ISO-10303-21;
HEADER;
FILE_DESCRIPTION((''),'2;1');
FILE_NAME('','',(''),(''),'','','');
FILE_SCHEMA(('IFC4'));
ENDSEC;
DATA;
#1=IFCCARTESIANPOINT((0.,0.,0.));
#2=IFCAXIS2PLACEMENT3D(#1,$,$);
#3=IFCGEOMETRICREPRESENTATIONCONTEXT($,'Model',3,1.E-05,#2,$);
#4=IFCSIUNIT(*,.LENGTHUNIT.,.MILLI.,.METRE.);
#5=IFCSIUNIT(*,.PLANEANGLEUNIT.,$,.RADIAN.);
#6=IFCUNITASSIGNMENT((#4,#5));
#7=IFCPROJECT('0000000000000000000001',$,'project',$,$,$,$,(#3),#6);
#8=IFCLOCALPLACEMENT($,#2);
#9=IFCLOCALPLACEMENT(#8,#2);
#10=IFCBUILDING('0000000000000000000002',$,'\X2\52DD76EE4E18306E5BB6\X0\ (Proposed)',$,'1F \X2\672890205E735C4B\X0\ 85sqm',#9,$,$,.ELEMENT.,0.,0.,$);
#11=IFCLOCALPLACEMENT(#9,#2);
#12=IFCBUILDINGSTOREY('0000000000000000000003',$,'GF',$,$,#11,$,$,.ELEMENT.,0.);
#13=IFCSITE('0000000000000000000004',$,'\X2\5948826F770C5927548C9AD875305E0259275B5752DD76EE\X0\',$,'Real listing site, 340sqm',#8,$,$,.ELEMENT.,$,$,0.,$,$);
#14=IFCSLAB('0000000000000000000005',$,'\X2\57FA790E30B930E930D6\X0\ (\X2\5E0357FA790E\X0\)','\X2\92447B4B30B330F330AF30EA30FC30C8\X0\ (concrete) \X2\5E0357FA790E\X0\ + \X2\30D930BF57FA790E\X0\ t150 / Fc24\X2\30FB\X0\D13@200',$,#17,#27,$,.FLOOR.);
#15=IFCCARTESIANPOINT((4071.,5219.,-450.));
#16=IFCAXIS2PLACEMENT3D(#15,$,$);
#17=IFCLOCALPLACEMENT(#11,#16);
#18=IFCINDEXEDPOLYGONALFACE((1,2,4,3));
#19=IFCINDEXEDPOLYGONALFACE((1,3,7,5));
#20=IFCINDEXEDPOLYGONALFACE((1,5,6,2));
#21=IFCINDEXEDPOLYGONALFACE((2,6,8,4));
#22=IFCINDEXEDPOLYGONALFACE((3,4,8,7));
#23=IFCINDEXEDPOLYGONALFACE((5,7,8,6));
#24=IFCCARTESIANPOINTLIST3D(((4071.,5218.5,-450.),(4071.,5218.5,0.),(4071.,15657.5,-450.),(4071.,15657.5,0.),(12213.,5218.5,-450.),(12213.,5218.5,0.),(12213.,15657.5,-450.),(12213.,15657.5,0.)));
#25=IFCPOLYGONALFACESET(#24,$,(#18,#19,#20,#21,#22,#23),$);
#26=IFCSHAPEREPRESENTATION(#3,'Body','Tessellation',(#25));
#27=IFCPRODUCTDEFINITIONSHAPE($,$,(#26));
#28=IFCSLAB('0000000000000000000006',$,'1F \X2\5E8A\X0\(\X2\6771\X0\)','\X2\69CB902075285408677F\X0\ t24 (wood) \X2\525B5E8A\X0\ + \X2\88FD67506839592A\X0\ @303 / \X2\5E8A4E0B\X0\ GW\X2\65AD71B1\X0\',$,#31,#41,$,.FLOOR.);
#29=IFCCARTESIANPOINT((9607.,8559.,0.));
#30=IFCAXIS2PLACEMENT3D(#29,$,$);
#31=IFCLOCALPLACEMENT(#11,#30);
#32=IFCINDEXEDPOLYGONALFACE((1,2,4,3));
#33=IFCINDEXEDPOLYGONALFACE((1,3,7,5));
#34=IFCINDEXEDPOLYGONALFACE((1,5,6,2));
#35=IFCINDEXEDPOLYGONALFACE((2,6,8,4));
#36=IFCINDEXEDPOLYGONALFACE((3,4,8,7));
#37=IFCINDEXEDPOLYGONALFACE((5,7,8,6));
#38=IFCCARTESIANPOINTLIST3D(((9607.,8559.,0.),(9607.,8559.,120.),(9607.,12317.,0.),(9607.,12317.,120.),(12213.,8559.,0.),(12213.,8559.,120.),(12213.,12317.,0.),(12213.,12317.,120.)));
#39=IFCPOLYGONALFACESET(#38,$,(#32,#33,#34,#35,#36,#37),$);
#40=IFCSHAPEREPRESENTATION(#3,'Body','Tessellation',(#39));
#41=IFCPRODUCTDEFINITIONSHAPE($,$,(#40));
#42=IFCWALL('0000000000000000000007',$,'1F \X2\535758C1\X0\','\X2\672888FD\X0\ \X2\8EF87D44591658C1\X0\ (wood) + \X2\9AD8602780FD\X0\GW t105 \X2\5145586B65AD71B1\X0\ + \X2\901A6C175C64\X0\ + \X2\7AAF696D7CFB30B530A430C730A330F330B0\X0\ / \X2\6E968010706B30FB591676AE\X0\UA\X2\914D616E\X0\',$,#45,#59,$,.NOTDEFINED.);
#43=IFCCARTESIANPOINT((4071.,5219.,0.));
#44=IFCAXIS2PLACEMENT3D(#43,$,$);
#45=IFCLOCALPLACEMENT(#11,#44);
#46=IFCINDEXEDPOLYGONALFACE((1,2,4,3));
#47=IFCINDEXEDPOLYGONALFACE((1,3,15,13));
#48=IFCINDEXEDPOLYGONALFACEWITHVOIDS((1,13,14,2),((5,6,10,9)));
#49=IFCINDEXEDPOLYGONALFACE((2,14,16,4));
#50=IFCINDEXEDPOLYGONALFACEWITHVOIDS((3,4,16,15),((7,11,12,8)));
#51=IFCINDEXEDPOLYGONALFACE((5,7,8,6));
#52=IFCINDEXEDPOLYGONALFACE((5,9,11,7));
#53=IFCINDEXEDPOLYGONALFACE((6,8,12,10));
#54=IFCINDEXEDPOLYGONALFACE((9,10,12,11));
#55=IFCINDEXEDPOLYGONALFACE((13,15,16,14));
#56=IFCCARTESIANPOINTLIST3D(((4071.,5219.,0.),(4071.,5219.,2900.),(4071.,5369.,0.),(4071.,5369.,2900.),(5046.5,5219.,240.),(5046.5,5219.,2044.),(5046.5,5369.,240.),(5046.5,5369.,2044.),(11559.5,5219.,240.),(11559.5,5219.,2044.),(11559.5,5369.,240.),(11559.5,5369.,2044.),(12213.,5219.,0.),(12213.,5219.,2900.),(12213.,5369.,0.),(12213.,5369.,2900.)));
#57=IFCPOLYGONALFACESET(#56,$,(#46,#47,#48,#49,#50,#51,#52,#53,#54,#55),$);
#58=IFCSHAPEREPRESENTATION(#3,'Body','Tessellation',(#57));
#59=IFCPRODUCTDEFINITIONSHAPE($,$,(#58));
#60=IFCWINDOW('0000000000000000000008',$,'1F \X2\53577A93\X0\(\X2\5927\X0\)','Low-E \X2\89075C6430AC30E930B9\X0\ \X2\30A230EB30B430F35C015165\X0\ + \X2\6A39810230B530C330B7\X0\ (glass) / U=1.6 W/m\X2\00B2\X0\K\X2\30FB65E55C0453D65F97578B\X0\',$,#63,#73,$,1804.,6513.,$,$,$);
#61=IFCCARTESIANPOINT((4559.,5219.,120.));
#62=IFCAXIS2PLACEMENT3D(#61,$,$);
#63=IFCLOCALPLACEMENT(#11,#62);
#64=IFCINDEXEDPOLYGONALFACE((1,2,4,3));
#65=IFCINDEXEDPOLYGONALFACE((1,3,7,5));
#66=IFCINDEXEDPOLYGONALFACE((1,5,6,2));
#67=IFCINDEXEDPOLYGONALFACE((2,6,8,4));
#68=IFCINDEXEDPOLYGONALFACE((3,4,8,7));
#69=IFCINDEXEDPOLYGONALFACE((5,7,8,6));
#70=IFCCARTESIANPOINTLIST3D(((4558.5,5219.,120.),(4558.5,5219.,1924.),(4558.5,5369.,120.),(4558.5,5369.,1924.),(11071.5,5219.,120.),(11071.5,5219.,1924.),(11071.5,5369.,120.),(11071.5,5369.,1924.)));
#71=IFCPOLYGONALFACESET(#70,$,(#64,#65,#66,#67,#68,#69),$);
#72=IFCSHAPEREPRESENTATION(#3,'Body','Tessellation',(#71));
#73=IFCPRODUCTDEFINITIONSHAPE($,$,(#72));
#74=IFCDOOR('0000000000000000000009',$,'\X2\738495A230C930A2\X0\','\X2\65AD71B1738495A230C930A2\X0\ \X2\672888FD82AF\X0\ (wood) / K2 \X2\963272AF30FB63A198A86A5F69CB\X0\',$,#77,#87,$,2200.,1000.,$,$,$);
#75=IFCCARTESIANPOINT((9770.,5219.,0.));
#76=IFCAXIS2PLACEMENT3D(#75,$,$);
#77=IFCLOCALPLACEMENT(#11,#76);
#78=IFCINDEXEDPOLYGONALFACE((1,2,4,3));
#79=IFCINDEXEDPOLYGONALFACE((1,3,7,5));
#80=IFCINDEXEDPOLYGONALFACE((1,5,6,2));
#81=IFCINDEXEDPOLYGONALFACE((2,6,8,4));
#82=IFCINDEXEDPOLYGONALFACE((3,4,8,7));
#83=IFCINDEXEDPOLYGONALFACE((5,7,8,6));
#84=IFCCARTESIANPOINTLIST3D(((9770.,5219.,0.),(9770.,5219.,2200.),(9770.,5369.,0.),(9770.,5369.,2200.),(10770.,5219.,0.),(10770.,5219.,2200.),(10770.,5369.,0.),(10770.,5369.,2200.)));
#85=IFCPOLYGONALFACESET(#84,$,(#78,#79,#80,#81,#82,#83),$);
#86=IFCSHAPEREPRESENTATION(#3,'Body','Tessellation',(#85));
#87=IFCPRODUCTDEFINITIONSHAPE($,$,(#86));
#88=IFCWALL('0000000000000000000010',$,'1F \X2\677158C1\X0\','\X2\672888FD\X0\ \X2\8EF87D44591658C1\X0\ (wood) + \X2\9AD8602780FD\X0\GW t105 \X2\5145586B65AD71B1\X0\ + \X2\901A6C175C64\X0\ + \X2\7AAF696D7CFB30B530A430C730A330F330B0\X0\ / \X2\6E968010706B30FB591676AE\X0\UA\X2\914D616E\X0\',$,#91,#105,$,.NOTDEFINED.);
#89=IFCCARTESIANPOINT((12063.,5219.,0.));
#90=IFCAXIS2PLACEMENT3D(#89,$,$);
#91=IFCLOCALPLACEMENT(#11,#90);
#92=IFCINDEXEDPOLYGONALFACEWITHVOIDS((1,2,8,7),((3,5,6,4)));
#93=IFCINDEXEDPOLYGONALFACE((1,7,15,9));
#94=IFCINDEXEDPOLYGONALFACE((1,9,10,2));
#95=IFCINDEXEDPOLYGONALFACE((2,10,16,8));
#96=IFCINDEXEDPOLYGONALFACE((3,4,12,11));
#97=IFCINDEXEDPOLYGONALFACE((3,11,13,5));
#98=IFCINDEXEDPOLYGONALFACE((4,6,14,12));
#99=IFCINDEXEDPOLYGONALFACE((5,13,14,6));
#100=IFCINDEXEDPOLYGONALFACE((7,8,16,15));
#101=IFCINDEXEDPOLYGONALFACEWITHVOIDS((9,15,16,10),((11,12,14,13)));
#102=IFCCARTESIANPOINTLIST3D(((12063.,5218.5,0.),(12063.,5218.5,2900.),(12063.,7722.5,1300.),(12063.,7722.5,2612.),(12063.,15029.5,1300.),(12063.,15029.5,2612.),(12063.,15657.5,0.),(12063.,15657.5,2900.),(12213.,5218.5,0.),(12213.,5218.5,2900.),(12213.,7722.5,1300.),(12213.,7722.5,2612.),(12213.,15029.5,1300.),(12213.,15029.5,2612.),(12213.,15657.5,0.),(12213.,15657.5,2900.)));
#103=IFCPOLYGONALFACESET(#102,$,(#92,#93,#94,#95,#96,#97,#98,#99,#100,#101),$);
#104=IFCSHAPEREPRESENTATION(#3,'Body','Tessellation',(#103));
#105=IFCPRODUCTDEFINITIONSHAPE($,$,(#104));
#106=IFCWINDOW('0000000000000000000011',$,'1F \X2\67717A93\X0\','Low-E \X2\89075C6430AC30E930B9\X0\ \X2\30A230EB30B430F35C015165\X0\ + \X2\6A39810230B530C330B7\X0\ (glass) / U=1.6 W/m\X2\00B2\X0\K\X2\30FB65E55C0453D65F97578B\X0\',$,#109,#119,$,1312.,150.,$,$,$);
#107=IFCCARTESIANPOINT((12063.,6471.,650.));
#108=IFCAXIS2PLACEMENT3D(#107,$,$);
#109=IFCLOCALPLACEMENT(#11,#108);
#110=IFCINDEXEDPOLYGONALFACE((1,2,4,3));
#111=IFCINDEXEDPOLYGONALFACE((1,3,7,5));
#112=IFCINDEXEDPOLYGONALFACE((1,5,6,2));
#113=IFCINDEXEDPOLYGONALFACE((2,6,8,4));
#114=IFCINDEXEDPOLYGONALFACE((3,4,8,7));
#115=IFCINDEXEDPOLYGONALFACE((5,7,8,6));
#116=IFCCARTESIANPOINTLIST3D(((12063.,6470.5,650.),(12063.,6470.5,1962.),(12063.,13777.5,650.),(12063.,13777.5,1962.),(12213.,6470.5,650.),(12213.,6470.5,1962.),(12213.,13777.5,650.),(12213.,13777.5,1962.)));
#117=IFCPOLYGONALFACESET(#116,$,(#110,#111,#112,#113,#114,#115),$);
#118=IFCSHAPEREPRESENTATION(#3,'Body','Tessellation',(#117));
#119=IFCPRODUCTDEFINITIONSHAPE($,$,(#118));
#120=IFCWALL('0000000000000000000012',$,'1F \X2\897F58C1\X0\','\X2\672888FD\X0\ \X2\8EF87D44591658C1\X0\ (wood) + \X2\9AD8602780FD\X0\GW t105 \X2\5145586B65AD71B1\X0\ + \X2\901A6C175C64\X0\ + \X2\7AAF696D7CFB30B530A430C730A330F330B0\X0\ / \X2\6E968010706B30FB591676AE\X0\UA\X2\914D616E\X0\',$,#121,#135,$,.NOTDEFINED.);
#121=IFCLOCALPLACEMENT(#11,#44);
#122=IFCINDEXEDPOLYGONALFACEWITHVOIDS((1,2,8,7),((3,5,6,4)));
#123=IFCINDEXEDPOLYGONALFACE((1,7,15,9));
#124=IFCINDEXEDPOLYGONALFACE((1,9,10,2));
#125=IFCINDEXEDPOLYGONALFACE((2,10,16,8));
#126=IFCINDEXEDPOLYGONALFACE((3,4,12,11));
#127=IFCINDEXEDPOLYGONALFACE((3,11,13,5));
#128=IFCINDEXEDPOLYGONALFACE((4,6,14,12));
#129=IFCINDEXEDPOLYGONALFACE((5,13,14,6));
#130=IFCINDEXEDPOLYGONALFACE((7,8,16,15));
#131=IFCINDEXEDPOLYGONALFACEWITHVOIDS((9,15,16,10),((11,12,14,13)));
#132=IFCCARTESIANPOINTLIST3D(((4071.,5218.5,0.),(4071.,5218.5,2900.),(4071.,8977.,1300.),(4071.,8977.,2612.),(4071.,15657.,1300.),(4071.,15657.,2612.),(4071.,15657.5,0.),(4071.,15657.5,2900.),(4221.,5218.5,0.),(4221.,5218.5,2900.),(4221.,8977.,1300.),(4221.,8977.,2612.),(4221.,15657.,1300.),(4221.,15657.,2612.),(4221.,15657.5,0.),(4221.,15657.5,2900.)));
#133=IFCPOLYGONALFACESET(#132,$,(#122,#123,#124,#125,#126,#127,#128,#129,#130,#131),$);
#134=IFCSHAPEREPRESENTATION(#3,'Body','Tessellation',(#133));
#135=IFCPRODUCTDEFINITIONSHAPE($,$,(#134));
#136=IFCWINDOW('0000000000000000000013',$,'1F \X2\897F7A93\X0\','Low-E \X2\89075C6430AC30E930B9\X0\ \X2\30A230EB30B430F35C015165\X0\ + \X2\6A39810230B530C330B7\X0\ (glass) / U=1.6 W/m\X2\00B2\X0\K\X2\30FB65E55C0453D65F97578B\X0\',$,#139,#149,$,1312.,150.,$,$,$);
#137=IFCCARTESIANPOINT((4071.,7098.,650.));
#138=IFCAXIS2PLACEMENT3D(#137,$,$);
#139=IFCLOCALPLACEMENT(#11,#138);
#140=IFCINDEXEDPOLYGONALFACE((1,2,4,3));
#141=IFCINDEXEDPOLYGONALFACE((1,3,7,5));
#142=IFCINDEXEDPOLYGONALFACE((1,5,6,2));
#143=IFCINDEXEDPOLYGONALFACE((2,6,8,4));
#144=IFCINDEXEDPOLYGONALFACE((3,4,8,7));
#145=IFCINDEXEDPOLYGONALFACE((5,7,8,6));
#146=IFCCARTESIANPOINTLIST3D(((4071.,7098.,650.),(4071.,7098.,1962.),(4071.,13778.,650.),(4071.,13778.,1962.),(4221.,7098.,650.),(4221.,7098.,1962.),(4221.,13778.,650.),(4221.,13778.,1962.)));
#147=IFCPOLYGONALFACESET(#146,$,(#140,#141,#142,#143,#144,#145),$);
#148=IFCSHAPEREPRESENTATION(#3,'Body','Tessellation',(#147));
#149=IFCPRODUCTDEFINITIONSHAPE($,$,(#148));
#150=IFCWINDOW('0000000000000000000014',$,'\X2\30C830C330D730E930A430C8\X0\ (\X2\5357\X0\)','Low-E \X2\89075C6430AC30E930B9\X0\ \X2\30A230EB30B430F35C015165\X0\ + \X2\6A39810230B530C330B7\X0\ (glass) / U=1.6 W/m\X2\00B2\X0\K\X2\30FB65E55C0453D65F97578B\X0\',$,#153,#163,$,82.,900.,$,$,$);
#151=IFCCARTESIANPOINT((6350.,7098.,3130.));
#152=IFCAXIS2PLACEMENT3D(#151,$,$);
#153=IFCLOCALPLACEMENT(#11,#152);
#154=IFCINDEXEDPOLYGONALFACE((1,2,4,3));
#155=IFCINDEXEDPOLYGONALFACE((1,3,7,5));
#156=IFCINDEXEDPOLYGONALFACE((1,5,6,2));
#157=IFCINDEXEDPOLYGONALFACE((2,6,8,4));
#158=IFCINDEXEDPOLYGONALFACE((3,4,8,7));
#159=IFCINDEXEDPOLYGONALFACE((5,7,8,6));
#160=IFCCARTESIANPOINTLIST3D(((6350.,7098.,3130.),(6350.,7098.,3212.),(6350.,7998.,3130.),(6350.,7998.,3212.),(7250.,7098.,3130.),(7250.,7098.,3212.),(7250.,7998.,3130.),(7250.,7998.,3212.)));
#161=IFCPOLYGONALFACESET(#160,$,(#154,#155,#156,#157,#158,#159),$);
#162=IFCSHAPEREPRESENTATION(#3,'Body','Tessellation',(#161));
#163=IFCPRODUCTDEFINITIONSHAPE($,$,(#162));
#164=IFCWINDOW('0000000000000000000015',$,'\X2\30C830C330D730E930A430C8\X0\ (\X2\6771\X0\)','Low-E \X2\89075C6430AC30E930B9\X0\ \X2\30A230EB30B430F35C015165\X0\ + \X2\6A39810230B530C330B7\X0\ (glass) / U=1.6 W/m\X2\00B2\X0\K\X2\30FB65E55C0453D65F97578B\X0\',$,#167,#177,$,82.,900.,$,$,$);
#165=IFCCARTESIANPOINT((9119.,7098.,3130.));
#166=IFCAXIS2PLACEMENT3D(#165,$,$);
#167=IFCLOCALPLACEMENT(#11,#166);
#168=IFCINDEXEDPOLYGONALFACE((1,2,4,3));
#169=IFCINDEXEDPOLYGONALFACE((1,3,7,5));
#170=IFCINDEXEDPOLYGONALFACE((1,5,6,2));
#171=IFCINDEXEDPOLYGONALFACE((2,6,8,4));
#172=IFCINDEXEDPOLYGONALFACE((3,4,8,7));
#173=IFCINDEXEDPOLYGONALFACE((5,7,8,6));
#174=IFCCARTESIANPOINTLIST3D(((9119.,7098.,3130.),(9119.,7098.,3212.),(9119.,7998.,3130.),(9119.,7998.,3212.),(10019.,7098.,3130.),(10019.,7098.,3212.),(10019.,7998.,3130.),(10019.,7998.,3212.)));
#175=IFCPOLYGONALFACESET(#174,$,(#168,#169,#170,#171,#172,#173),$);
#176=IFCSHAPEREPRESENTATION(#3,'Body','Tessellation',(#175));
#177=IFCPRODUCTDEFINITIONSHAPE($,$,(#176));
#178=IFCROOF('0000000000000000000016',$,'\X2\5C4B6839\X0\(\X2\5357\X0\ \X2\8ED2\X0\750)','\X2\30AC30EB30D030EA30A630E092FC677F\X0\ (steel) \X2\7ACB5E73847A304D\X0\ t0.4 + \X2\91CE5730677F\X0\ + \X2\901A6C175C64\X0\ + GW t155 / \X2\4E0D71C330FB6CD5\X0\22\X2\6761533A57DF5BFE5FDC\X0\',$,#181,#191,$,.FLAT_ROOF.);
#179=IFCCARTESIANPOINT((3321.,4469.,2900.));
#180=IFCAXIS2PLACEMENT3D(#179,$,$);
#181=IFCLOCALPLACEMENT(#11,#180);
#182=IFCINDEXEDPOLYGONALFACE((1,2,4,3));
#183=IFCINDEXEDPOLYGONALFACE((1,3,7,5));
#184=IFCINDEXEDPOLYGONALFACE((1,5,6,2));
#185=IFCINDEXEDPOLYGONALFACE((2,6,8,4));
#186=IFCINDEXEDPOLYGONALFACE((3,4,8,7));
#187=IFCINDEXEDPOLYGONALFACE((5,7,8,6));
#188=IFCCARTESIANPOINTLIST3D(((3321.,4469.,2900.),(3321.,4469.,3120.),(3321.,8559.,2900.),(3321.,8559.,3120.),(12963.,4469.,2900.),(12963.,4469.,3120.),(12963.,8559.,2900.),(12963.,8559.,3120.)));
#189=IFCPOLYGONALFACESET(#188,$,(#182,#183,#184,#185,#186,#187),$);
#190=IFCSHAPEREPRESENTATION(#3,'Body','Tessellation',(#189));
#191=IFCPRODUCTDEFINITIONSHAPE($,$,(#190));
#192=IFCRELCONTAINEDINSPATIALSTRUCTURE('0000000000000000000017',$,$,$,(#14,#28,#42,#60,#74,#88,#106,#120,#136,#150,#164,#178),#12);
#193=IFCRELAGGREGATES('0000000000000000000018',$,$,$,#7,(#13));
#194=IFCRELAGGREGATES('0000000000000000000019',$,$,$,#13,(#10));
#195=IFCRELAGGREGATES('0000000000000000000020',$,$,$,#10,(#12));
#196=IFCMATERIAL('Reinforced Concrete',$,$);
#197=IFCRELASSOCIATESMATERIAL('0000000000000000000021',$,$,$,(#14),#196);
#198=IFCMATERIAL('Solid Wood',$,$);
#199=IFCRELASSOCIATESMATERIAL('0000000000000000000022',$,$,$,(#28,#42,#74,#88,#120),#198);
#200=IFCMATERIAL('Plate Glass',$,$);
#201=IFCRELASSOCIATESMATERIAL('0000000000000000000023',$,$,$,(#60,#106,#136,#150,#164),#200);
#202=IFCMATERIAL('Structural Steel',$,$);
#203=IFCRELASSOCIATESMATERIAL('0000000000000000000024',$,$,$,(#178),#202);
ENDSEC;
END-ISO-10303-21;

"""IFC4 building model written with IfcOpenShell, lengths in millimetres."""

from ifc_helpers import new_model, si_unit, frame, frame_2d, origin, place, context, project, spatial, rectangle, extrude, material, element, fill, save


model = new_model("IFC4")

# Units and contexts
model_context = context("Model", 3, precision=1e-05, world=origin())
ifc_project = project(units=[si_unit("LENGTHUNIT", "METRE", prefix="MILLI"), si_unit("PLANEANGLEUNIT", "RADIAN")], contexts=[model_context])

# Site, building, storey
site_placement = place(None, origin())
site = spatial("IfcSite", under=ifc_project, at=site_placement, Name="奈良県大和高田市大字勝目", ObjectType="Real listing site, 340sqm", CompositionType="ELEMENT", RefElevation=0.0)
building_placement = place(site_placement, origin())
building = spatial("IfcBuilding", under=site, at=building_placement, Name="勝目丘の家 (Proposed)", ObjectType="1F 木造平屋 85sqm", CompositionType="ELEMENT", ElevationOfRefHeight=0.0, ElevationOfTerrain=0.0)
storey_placement = place(building_placement, origin())
storey = spatial("IfcBuildingStorey", under=building, at=storey_placement, Name="GF", CompositionType="ELEMENT", Elevation=0.0)

# Slabs
ifc_material_1 = material(Name="Reinforced Concrete")
slab_1_placement = place(storey_placement, frame((4071.0, 5219.0, -450.0)))
element("IfcSlab", 1, at=slab_1_placement, inside=storey, material=ifc_material_1, Name="基礎スラブ (布基礎)", Description="鉄筋コンクリート (concrete) 布基礎 + ベタ基礎 t150 / Fc24・D13@200", PredefinedType="FLOOR", context=model_context, shape_type="SweptSolid", body=[
    extrude(rectangle(XDim=8142.0, YDim=10439.0, at=frame_2d((4071.0, 5219.0))), frame((4071.0, 5219.0, -450.0)), (0.0, 0.0, 1.0), 450.0),
])
ifc_material_2 = material(Name="Solid Wood")
slab_2_placement = place(storey_placement, frame((9607.0, 8559.0, 0.0)))
element("IfcSlab", 2, at=slab_2_placement, inside=storey, material=ifc_material_2, Name="1F 床(東)", Description="構造用合板 t24 (wood) 剛床 + 製材根太 @303 / 床下 GW断熱", PredefinedType="FLOOR", context=model_context, shape_type="SweptSolid", body=[
    extrude(rectangle(XDim=2606.0, YDim=3758.0, at=frame_2d((1303.0, 1879.0))), frame((9607.0, 8559.0, 0.0)), (0.0, 0.0, 1.0), 120.0),
])

# Wall, openings, window, door
wall_1_placement = place(storey_placement, frame((4071.0, 5219.0, 0.0)))
wall_1 = element("IfcWall", 3, at=wall_1_placement, inside=storey, material=ifc_material_2, Name="1F 南壁", Description="木製 軸組外壁 (wood) + 高性能GW t105 充填断熱 + 通気層 + 窯業系サイディング / 準耐火・外皮UA配慮", PredefinedType="NOTDEFINED", context=model_context, shape_type="SweptSolid", body=[
    extrude(rectangle(XDim=8142.0, YDim=150.0, at=frame_2d((4071.0, 75.0))), frame((4071.0, 5219.0, 0.0)), (0.0, 0.0, 1.0), 2900.0),
])
opening_1_placement = place(storey_placement, frame((4559.0, 5219.0, 120.0)))
opening_1 = element("IfcOpeningElement", 4, at=opening_1_placement, cuts=wall_1, PredefinedType="NOTDEFINED", context=model_context, shape_type="SweptSolid", body=[
    extrude(rectangle(XDim=6513.0, YDim=150.0, at=frame_2d((3256.0, 75.0))), frame((4559.0, 5219.0, 120.0)), (0.0, 0.0, 1.0), 1804.0),
])
opening_2_placement = place(storey_placement, frame((9770.0, 5219.0, 0.0)))
opening_2 = element("IfcOpeningElement", 5, at=opening_2_placement, cuts=wall_1, PredefinedType="NOTDEFINED", context=model_context, shape_type="SweptSolid", body=[
    extrude(rectangle(XDim=1000.0, YDim=150.0, at=frame_2d((500.0, 75.0))), frame((9770.0, 5219.0, 0.0)), (0.0, 0.0, 1.0), 2200.0),
])
ifc_material_3 = material(Name="Plate Glass")
window_1_placement = place(storey_placement, frame((4559.0, 5219.0, 120.0)))
window_1 = element("IfcWindow", 6, at=window_1_placement, inside=storey, material=ifc_material_3, Name="1F 南窓(大)", Description="Low-E 複層ガラス アルゴン封入 + 樹脂サッシ (glass) / U=1.6 W/m²K・日射取得型", OverallHeight=1804.0, OverallWidth=6513.0, context=model_context, shape_type="SweptSolid", body=[
    extrude(rectangle(XDim=6513.0, YDim=150.0, at=frame_2d((3256.0, 75.0))), frame((4559.0, 5219.0, 120.0)), (0.0, 0.0, 1.0), 1804.0),
])
fill(opening_1, window_1)
door_placement = place(storey_placement, frame((9770.0, 5219.0, 0.0)))
door = element("IfcDoor", 7, at=door_placement, inside=storey, material=ifc_material_2, Name="玄関ドア", Description="断熱玄関ドア 木製芯 (wood) / K2 防犯・採風機構", OverallHeight=2200.0, OverallWidth=1000.0, context=model_context, shape_type="SweptSolid", body=[
    extrude(rectangle(XDim=1000.0, YDim=150.0, at=frame_2d((500.0, 75.0))), frame((9770.0, 5219.0, 0.0)), (0.0, 0.0, 1.0), 2200.0),
])
fill(opening_2, door)

# Walls, openings, windows
wall_2_placement = place(storey_placement, frame((12063.0, 5219.0, 0.0)))
wall_2 = element("IfcWall", 8, at=wall_2_placement, inside=storey, material=ifc_material_2, Name="1F 東壁", Description="木製 軸組外壁 (wood) + 高性能GW t105 充填断熱 + 通気層 + 窯業系サイディング / 準耐火・外皮UA配慮", PredefinedType="NOTDEFINED", context=model_context, shape_type="SweptSolid", body=[
    extrude(rectangle(XDim=150.0, YDim=10439.0, at=frame_2d((75.0, 5219.0))), frame((12063.0, 5219.0, 0.0)), (0.0, 0.0, 1.0), 2900.0),
])
opening_3_placement = place(storey_placement, frame((12063.0, 6471.0, 650.0)))
opening_3 = element("IfcOpeningElement", 9, at=opening_3_placement, cuts=wall_2, PredefinedType="NOTDEFINED", context=model_context, shape_type="SweptSolid", body=[
    extrude(rectangle(XDim=150.0, YDim=7307.0, at=frame_2d((75.0, 3653.0))), frame((12063.0, 6471.0, 650.0)), (0.0, 0.0, 1.0), 1312.0),
])
window_2_placement = place(storey_placement, frame((12063.0, 6471.0, 650.0)))
window_2 = element("IfcWindow", 10, at=window_2_placement, inside=storey, material=ifc_material_3, Name="1F 東窓", Description="Low-E 複層ガラス アルゴン封入 + 樹脂サッシ (glass) / U=1.6 W/m²K・日射取得型", OverallHeight=1312.0, OverallWidth=150.0, context=model_context, shape_type="SweptSolid", body=[
    extrude(rectangle(XDim=150.0, YDim=7307.0, at=frame_2d((75.0, 3653.0))), frame((12063.0, 6471.0, 650.0)), (0.0, 0.0, 1.0), 1312.0),
])
fill(opening_3, window_2)
wall_3_placement = place(storey_placement, frame((4071.0, 5219.0, 0.0)))
wall_3 = element("IfcWall", 11, at=wall_3_placement, inside=storey, material=ifc_material_2, Name="1F 西壁", Description="木製 軸組外壁 (wood) + 高性能GW t105 充填断熱 + 通気層 + 窯業系サイディング / 準耐火・外皮UA配慮", PredefinedType="NOTDEFINED", context=model_context, shape_type="SweptSolid", body=[
    extrude(rectangle(XDim=150.0, YDim=10439.0, at=frame_2d((75.0, 5219.0))), frame((4071.0, 5219.0, 0.0)), (0.0, 0.0, 1.0), 2900.0),
])
opening_4_placement = place(storey_placement, frame((4071.0, 7098.0, 650.0)))
opening_4 = element("IfcOpeningElement", 12, at=opening_4_placement, cuts=wall_3, PredefinedType="NOTDEFINED", context=model_context, shape_type="SweptSolid", body=[
    extrude(rectangle(XDim=150.0, YDim=6680.0, at=frame_2d((75.0, 3340.0))), frame((4071.0, 7098.0, 650.0)), (0.0, 0.0, 1.0), 1312.0),
])
window_3_placement = place(storey_placement, frame((4071.0, 7098.0, 650.0)))
window_3 = element("IfcWindow", 13, at=window_3_placement, inside=storey, material=ifc_material_3, Name="1F 西窓", Description="Low-E 複層ガラス アルゴン封入 + 樹脂サッシ (glass) / U=1.6 W/m²K・日射取得型", OverallHeight=1312.0, OverallWidth=150.0, context=model_context, shape_type="SweptSolid", body=[
    extrude(rectangle(XDim=150.0, YDim=6680.0, at=frame_2d((75.0, 3340.0))), frame((4071.0, 7098.0, 650.0)), (0.0, 0.0, 1.0), 1312.0),
])
fill(opening_4, window_3)

# Windows
window_4_placement = place(storey_placement, frame((6350.0, 7098.0, 3130.0)))
element("IfcWindow", 14, at=window_4_placement, inside=storey, material=ifc_material_3, Name="トップライト (南)", Description="Low-E 複層ガラス アルゴン封入 + 樹脂サッシ (glass) / U=1.6 W/m²K・日射取得型", OverallHeight=82.0, OverallWidth=900.0, context=model_context, shape_type="SweptSolid", body=[
    extrude(rectangle(XDim=900.0, YDim=900.0, at=frame_2d((450.0, 450.0))), frame((6350.0, 7098.0, 3130.0)), (0.0, 0.0, 1.0), 82.0),
])
window_5_placement = place(storey_placement, frame((9119.0, 7098.0, 3130.0)))
element("IfcWindow", 15, at=window_5_placement, inside=storey, material=ifc_material_3, Name="トップライト (東)", Description="Low-E 複層ガラス アルゴン封入 + 樹脂サッシ (glass) / U=1.6 W/m²K・日射取得型", OverallHeight=82.0, OverallWidth=900.0, context=model_context, shape_type="SweptSolid", body=[
    extrude(rectangle(XDim=900.0, YDim=900.0, at=frame_2d((450.0, 450.0))), frame((9119.0, 7098.0, 3130.0)), (0.0, 0.0, 1.0), 82.0),
])

# Roof
ifc_material_4 = material(Name="Structural Steel")
roof_placement = place(storey_placement, frame((3321.0, 4469.0, 2900.0)))
element("IfcRoof", 16, at=roof_placement, inside=storey, material=ifc_material_4, Name="屋根(南 軒750)", Description="ガルバリウム鋼板 (steel) 立平葺き t0.4 + 野地板 + 通気層 + GW t155 / 不燃・法22条区域対応", PredefinedType="FLAT_ROOF", context=model_context, shape_type="SweptSolid", body=[
    extrude(rectangle(XDim=9642.0, YDim=4090.0, at=frame_2d((4821.0, 2045.0))), frame((3321.0, 4469.0, 2900.0)), (0.0, 0.0, 1.0), 220.0),
])

save(model, "model.ifc")
